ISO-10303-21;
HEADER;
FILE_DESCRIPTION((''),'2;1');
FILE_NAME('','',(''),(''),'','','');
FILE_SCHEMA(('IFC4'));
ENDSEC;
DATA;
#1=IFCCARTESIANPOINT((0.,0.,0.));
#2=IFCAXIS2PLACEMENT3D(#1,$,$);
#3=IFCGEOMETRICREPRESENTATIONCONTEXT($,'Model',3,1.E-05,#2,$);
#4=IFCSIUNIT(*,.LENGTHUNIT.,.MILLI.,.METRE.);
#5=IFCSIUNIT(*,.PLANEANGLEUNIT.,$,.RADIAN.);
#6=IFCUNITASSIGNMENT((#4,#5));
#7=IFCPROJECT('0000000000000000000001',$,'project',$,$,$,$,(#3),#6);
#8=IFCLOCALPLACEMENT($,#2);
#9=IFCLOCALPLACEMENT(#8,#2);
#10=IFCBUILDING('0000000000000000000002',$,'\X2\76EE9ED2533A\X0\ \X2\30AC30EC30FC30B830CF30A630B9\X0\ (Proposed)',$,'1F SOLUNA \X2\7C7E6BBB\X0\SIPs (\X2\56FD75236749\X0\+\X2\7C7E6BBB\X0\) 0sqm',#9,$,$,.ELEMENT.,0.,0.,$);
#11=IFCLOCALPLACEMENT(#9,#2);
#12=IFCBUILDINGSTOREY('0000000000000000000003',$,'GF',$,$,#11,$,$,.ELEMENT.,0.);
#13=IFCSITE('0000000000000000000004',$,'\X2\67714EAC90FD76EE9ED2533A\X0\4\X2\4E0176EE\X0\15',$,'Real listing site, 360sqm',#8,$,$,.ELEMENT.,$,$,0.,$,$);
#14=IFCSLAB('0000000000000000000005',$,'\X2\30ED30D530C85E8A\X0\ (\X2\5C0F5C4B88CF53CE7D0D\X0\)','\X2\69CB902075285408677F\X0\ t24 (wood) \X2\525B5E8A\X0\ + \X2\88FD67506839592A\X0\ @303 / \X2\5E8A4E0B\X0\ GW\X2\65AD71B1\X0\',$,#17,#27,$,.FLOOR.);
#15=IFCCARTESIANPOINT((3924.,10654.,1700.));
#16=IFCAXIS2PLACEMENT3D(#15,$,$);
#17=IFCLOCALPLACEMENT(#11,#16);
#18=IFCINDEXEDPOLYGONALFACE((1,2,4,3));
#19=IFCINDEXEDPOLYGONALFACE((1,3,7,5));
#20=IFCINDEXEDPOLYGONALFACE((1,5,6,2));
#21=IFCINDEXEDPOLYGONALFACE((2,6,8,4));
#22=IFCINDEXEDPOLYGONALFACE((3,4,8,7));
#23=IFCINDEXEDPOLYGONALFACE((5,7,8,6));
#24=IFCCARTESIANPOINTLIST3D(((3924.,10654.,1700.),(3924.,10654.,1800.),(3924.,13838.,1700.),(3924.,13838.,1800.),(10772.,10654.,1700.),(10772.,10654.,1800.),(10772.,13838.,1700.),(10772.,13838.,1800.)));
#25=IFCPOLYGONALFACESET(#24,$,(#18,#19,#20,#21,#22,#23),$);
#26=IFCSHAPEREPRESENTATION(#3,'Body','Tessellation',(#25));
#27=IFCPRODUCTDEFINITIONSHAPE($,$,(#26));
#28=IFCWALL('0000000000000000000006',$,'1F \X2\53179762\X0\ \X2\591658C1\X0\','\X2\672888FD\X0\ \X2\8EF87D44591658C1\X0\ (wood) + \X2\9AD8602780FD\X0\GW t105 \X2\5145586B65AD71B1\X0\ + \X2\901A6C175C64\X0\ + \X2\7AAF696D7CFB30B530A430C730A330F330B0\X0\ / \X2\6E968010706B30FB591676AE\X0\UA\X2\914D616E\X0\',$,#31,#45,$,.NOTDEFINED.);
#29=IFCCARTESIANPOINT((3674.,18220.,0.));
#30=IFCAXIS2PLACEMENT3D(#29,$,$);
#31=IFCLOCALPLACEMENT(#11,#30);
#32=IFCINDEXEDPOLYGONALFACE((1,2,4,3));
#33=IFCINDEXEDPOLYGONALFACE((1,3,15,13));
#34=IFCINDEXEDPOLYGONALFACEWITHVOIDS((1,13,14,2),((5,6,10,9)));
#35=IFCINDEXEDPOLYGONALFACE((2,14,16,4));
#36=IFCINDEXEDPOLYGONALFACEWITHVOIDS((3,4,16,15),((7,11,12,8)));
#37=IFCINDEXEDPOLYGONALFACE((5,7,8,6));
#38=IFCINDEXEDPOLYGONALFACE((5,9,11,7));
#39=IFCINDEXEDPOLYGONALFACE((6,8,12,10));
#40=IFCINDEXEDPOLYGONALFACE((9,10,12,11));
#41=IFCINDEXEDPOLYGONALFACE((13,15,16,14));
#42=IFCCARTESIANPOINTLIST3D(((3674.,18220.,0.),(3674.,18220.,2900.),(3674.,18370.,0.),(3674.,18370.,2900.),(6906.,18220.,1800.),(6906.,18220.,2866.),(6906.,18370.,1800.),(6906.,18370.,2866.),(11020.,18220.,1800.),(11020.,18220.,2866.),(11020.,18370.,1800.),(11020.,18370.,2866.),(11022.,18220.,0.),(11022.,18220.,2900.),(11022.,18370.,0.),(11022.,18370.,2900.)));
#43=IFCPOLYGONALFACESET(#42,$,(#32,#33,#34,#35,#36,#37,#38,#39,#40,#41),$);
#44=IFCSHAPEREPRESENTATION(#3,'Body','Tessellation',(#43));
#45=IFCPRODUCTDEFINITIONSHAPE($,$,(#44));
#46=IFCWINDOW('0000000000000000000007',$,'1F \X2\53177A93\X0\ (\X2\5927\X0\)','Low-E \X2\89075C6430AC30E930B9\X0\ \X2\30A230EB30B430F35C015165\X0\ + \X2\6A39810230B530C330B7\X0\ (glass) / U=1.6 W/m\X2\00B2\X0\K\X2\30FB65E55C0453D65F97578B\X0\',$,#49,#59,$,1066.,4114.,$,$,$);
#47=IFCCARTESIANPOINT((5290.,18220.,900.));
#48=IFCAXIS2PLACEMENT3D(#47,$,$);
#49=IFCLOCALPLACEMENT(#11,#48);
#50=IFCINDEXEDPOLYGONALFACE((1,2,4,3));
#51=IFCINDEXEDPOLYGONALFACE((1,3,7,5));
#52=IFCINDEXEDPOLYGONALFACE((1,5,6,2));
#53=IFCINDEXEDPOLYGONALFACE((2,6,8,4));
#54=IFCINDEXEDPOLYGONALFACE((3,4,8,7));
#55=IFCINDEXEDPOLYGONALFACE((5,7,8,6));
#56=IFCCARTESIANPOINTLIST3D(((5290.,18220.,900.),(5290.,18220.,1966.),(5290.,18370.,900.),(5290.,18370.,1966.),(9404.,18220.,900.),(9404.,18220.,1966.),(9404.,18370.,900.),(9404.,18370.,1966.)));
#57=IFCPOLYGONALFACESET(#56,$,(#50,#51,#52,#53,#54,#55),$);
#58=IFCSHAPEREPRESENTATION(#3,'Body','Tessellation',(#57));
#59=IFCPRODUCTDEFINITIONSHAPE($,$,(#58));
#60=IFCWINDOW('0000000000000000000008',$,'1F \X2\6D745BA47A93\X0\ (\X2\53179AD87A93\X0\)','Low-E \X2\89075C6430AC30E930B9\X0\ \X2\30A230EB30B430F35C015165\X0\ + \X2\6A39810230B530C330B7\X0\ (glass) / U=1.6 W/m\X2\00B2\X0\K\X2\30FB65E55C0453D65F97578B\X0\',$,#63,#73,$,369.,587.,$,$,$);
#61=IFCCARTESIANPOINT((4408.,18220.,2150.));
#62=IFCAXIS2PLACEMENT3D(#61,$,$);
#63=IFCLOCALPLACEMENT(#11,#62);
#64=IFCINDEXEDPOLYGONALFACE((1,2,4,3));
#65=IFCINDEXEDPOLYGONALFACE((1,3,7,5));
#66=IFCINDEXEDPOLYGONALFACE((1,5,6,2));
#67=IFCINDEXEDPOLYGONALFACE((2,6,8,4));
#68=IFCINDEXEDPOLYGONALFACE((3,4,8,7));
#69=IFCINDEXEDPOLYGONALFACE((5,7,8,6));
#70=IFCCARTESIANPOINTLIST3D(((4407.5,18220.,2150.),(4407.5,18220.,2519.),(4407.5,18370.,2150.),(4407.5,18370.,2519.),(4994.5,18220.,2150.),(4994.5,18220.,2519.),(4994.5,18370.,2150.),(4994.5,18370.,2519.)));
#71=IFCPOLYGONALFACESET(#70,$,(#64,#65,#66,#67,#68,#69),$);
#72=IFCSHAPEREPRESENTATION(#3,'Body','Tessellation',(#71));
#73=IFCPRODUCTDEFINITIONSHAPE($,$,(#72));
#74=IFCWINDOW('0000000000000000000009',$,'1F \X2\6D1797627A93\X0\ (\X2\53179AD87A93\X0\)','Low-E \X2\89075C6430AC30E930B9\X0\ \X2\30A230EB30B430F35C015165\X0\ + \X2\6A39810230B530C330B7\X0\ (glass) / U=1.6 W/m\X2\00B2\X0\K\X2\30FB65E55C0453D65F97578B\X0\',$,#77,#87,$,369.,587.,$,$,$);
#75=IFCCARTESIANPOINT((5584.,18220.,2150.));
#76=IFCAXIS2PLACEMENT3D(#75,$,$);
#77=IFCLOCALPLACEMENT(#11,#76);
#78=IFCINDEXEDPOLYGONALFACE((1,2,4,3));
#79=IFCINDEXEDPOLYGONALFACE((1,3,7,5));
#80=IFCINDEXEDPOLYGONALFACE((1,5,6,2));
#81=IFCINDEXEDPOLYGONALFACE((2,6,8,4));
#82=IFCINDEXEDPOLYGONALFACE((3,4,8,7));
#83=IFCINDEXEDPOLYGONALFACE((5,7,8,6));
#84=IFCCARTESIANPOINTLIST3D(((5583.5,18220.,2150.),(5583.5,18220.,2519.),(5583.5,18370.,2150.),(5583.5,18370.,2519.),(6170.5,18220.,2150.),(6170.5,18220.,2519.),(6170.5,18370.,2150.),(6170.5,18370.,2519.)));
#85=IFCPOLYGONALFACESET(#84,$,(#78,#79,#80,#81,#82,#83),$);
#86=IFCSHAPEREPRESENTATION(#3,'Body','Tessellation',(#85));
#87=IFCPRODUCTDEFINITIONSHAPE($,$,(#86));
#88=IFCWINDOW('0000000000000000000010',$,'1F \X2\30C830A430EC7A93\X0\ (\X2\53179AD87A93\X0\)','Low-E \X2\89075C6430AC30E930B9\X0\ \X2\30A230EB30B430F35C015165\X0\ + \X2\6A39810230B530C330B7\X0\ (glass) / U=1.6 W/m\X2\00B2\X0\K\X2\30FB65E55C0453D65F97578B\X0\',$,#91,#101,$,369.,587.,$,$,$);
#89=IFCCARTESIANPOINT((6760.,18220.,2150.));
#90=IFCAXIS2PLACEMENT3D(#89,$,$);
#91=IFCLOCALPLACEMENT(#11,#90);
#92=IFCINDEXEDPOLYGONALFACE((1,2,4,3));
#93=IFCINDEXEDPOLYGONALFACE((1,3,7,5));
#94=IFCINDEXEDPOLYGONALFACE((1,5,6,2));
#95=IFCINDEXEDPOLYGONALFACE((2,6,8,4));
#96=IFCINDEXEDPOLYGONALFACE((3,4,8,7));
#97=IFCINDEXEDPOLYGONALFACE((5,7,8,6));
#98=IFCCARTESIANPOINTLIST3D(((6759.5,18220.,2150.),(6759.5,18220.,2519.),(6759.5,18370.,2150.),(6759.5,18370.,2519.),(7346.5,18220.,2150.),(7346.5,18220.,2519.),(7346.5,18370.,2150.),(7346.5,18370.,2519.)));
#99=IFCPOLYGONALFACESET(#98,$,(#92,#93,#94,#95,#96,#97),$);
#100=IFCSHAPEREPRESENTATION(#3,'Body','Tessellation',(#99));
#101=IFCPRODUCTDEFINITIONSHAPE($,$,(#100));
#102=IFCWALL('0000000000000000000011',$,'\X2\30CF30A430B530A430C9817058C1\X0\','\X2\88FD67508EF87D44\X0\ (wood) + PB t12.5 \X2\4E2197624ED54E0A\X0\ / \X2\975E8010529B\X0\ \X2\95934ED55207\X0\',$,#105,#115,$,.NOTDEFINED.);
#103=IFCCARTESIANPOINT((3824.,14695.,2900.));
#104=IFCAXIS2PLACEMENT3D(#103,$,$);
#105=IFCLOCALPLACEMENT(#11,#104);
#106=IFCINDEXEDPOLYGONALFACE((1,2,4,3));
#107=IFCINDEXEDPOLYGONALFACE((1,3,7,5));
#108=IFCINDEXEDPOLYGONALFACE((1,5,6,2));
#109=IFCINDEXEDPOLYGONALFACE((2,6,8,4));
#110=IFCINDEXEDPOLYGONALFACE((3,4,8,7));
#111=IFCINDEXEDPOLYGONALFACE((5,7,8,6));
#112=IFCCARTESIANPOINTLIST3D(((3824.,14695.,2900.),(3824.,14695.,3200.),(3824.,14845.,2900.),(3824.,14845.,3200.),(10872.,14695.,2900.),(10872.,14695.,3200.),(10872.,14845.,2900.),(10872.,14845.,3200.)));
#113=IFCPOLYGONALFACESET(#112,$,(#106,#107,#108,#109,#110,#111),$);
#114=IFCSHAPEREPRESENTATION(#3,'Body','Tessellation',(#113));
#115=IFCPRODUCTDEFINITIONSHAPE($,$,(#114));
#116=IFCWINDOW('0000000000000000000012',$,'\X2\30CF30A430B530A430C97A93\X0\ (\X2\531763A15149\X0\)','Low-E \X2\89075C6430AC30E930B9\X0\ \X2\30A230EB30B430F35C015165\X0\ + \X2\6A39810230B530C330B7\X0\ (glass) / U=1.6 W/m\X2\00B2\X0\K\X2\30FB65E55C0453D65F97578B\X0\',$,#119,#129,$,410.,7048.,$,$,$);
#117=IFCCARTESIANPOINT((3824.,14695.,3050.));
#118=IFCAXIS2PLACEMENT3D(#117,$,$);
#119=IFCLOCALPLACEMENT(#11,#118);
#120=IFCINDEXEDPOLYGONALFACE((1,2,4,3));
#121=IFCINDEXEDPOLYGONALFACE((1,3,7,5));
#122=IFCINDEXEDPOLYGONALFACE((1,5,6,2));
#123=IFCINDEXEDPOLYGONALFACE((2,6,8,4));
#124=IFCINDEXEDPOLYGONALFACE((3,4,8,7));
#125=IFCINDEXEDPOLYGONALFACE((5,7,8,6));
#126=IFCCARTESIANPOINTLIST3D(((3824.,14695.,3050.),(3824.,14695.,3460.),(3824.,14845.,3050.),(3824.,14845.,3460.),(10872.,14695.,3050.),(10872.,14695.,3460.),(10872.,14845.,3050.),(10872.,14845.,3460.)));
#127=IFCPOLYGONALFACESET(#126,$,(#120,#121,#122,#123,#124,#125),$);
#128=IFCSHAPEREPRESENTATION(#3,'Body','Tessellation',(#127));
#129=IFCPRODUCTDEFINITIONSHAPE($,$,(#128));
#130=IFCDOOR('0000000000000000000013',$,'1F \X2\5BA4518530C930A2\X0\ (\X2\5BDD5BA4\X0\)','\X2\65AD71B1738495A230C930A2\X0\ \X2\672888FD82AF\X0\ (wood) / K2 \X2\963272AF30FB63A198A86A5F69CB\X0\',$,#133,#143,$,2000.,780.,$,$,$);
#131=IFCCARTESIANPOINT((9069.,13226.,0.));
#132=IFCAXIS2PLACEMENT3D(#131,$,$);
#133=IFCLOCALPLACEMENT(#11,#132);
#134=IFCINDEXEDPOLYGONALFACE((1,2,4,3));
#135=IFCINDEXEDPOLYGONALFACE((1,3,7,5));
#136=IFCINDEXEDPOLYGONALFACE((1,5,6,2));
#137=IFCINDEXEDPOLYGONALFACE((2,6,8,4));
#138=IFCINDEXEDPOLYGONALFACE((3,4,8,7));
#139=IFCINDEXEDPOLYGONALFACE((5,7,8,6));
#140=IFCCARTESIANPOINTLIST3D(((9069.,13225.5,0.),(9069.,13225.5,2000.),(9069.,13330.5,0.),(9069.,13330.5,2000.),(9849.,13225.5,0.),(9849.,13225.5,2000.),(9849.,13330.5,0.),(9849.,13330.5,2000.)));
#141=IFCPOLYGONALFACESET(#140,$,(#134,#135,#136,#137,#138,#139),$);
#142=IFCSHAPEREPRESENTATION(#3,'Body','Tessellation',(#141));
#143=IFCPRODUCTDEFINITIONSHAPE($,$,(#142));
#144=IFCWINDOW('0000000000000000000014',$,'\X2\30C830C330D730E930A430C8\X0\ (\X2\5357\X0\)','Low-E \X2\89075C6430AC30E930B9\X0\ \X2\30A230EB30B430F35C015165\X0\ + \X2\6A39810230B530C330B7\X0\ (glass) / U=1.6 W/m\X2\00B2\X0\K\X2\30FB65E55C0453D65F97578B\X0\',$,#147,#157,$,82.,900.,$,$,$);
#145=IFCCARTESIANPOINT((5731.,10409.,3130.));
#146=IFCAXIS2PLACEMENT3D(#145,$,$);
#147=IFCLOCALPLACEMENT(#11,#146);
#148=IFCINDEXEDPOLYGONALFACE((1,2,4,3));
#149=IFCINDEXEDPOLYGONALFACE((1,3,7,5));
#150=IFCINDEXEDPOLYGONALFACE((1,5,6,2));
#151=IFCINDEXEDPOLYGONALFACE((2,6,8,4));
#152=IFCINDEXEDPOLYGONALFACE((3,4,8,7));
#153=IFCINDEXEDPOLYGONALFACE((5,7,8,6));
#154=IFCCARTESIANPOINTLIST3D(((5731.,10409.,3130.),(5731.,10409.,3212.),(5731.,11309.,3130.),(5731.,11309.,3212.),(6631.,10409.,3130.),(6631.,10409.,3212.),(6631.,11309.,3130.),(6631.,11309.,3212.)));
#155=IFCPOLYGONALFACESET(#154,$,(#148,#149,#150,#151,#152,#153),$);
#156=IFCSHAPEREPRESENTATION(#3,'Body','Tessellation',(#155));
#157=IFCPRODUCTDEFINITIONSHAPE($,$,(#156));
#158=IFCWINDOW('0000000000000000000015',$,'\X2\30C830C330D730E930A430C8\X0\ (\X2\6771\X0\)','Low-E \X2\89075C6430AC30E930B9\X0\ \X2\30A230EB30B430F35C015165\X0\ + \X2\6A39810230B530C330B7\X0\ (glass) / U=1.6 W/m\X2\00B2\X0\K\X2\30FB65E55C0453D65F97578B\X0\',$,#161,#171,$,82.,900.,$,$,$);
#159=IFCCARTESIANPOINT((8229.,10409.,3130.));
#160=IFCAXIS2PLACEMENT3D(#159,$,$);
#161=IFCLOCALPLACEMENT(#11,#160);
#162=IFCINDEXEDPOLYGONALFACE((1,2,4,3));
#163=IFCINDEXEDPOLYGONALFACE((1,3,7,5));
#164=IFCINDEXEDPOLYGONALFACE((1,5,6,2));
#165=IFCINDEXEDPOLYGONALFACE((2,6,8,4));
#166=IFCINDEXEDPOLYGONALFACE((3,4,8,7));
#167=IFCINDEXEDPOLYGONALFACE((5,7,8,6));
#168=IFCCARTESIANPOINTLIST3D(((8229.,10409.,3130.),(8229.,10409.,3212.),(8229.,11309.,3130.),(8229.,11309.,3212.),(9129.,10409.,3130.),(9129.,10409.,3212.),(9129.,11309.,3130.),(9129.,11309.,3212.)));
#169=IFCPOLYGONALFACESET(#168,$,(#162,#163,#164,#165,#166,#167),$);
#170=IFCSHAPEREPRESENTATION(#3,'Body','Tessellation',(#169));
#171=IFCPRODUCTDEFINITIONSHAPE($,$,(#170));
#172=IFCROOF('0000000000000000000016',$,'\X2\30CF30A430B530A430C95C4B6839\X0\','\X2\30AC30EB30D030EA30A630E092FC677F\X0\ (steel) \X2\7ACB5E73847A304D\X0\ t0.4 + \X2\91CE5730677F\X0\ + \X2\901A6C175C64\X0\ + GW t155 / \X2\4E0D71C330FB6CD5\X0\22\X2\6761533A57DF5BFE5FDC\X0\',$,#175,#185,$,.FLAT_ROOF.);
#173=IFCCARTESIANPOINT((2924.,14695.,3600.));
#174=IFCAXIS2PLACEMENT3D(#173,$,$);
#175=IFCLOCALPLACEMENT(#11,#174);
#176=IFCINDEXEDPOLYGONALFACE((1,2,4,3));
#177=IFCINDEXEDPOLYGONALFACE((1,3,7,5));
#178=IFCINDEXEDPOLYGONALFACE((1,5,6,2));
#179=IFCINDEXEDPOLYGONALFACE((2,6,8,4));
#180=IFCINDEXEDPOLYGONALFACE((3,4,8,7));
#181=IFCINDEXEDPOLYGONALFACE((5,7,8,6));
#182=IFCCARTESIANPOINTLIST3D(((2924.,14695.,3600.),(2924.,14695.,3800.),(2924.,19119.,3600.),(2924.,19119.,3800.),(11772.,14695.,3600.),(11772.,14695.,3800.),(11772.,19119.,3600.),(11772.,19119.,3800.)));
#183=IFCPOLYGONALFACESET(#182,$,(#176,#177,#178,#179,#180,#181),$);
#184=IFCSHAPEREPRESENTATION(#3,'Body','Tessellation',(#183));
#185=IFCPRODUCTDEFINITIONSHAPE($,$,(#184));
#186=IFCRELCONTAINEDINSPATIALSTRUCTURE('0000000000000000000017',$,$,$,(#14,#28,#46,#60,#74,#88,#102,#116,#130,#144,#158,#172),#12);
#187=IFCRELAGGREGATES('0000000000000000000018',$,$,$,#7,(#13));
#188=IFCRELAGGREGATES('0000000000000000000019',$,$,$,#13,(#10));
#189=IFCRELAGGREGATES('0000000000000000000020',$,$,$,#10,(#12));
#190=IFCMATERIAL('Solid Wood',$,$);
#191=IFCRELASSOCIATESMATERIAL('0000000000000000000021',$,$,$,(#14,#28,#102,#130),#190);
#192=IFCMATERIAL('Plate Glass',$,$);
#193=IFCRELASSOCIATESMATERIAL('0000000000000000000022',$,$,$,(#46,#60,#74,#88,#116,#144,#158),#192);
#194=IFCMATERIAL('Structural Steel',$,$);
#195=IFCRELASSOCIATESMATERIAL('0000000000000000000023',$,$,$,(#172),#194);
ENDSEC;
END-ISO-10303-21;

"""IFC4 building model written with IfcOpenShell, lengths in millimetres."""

from ifc_helpers import new_model, si_unit, frame, frame_2d, origin, place, context, project, spatial, rectangle, extrude, material, element, fill, save


model = new_model("IFC4")

# Units and contexts
model_context = context("Model", 3, precision=1e-05, world=origin())
ifc_project = project(units=[si_unit("LENGTHUNIT", "METRE", prefix="MILLI"), si_unit("PLANEANGLEUNIT", "RADIAN")], contexts=[model_context])

# Site, building, storey
site_placement = place(None, origin())
site = spatial("IfcSite", under=ifc_project, at=site_placement, Name="東京都目黒区4丁目15", ObjectType="Real listing site, 360sqm", CompositionType="ELEMENT", RefElevation=0.0)
building_placement = place(site_placement, origin())
building = spatial("IfcBuilding", under=site, at=building_placement, Name="目黒区 ガレージハウス (Proposed)", ObjectType="1F SOLUNA 籾殻SIPs (国産杉+籾殻) 0sqm", CompositionType="ELEMENT", ElevationOfRefHeight=0.0, ElevationOfTerrain=0.0)
storey_placement = place(building_placement, origin())
storey = spatial("IfcBuildingStorey", under=building, at=storey_placement, Name="GF", CompositionType="ELEMENT", Elevation=0.0)

# Slab
ifc_material_1 = material(Name="Solid Wood")
slab_placement = place(storey_placement, frame((3924.0, 10654.0, 1700.0)))
element("IfcSlab", 1, at=slab_placement, inside=storey, material=ifc_material_1, Name="ロフト床 (小屋裏収納)", Description="構造用合板 t24 (wood) 剛床 + 製材根太 @303 / 床下 GW断熱", PredefinedType="FLOOR", context=model_context, shape_type="SweptSolid", body=[
    extrude(rectangle(XDim=6848.0, YDim=3184.0, at=frame_2d((3424.0, 1592.0))), frame((3924.0, 10654.0, 1700.0)), (0.0, 0.0, 1.0), 100.0),
])

# Wall, openings, windows
wall_1_placement = place(storey_placement, frame((3674.0, 18220.0, 0.0)))
wall_1 = element("IfcWall", 2, at=wall_1_placement, inside=storey, material=ifc_material_1, Name="1F 北面 外壁", Description="木製 軸組外壁 (wood) + 高性能GW t105 充填断熱 + 通気層 + 窯業系サイディング / 準耐火・外皮UA配慮", PredefinedType="NOTDEFINED", context=model_context, shape_type="SweptSolid", body=[
    extrude(rectangle(XDim=7348.0, YDim=150.0, at=frame_2d((3674.0, 75.0))), frame((3674.0, 18220.0, 0.0)), (0.0, 0.0, 1.0), 2900.0),
])
opening_1_placement = place(storey_placement, frame((5290.0, 18220.0, 900.0)))
opening_1 = element("IfcOpeningElement", 3, at=opening_1_placement, cuts=wall_1, PredefinedType="NOTDEFINED", context=model_context, shape_type="SweptSolid", body=[
    extrude(rectangle(XDim=4114.0, YDim=150.0, at=frame_2d((2057.0, 75.0))), frame((5290.0, 18220.0, 900.0)), (0.0, 0.0, 1.0), 1066.0),
])
opening_2_placement = place(storey_placement, frame((4408.0, 18220.0, 2150.0)))
opening_2 = element("IfcOpeningElement", 4, at=opening_2_placement, cuts=wall_1, PredefinedType="NOTDEFINED", context=model_context, shape_type="SweptSolid", body=[
    extrude(rectangle(XDim=587.0, YDim=150.0, at=frame_2d((293.0, 75.0))), frame((4408.0, 18220.0, 2150.0)), (0.0, 0.0, 1.0), 369.0),
])
opening_3_placement = place(storey_placement, frame((5584.0, 18220.0, 2150.0)))
opening_3 = element("IfcOpeningElement", 5, at=opening_3_placement, cuts=wall_1, PredefinedType="NOTDEFINED", context=model_context, shape_type="SweptSolid", body=[
    extrude(rectangle(XDim=587.0, YDim=150.0, at=frame_2d((293.0, 75.0))), frame((5584.0, 18220.0, 2150.0)), (0.0, 0.0, 1.0), 369.0),
])
opening_4_placement = place(storey_placement, frame((6760.0, 18220.0, 2150.0)))
opening_4 = element("IfcOpeningElement", 6, at=opening_4_placement, cuts=wall_1, PredefinedType="NOTDEFINED", context=model_context, shape_type="SweptSolid", body=[
    extrude(rectangle(XDim=587.0, YDim=150.0, at=frame_2d((293.0, 75.0))), frame((6760.0, 18220.0, 2150.0)), (0.0, 0.0, 1.0), 369.0),
])
ifc_material_2 = material(Name="Plate Glass")
window_1_placement = place(storey_placement, frame((5290.0, 18220.0, 900.0)))
window_1 = element("IfcWindow", 7, at=window_1_placement, inside=storey, material=ifc_material_2, Name="1F 北窓 (大)", Description="Low-E 複層ガラス アルゴン封入 + 樹脂サッシ (glass) / U=1.6 W/m²K・日射取得型", OverallHeight=1066.0, OverallWidth=4114.0, context=model_context, shape_type="SweptSolid", body=[
    extrude(rectangle(XDim=4114.0, YDim=150.0, at=frame_2d((2057.0, 75.0))), frame((5290.0, 18220.0, 900.0)), (0.0, 0.0, 1.0), 1066.0),
])
fill(opening_1, window_1)
window_2_placement = place(storey_placement, frame((4408.0, 18220.0, 2150.0)))
window_2 = element("IfcWindow", 8, at=window_2_placement, inside=storey, material=ifc_material_2, Name="1F 浴室窓 (北高窓)", Description="Low-E 複層ガラス アルゴン封入 + 樹脂サッシ (glass) / U=1.6 W/m²K・日射取得型", OverallHeight=369.0, OverallWidth=587.0, context=model_context, shape_type="SweptSolid", body=[
    extrude(rectangle(XDim=587.0, YDim=150.0, at=frame_2d((293.0, 75.0))), frame((4408.0, 18220.0, 2150.0)), (0.0, 0.0, 1.0), 369.0),
])
fill(opening_2, window_2)
window_3_placement = place(storey_placement, frame((5584.0, 18220.0, 2150.0)))
window_3 = element("IfcWindow", 9, at=window_3_placement, inside=storey, material=ifc_material_2, Name="1F 洗面窓 (北高窓)", Description="Low-E 複層ガラス アルゴン封入 + 樹脂サッシ (glass) / U=1.6 W/m²K・日射取得型", OverallHeight=369.0, OverallWidth=587.0, context=model_context, shape_type="SweptSolid", body=[
    extrude(rectangle(XDim=587.0, YDim=150.0, at=frame_2d((293.0, 75.0))), frame((5584.0, 18220.0, 2150.0)), (0.0, 0.0, 1.0), 369.0),
])
fill(opening_3, window_3)
window_4_placement = place(storey_placement, frame((6760.0, 18220.0, 2150.0)))
window_4 = element("IfcWindow", 10, at=window_4_placement, inside=storey, material=ifc_material_2, Name="1F トイレ窓 (北高窓)", Description="Low-E 複層ガラス アルゴン封入 + 樹脂サッシ (glass) / U=1.6 W/m²K・日射取得型", OverallHeight=369.0, OverallWidth=587.0, context=model_context, shape_type="SweptSolid", body=[
    extrude(rectangle(XDim=587.0, YDim=150.0, at=frame_2d((293.0, 75.0))), frame((6760.0, 18220.0, 2150.0)), (0.0, 0.0, 1.0), 369.0),
])
fill(opening_4, window_4)

# Wall, opening, window
wall_2_placement = place(storey_placement, frame((3824.0, 14695.0, 2900.0)))
wall_2 = element("IfcWall", 11, at=wall_2_placement, inside=storey, material=ifc_material_1, Name="ハイサイド腰壁", Description="製材軸組 (wood) + PB t12.5 両面仕上 / 非耐力 間仕切", PredefinedType="NOTDEFINED", context=model_context, shape_type="SweptSolid", body=[
    extrude(rectangle(XDim=7048.0, YDim=150.0, at=frame_2d((3524.0, 75.0))), frame((3824.0, 14695.0, 2900.0)), (0.0, 0.0, 1.0), 700.0),
])
opening_5_placement = place(storey_placement, frame((3824.0, 14695.0, 3050.0)))
opening_5 = element("IfcOpeningElement", 12, at=opening_5_placement, cuts=wall_2, PredefinedType="NOTDEFINED", context=model_context, shape_type="SweptSolid", body=[
    extrude(rectangle(XDim=7048.0, YDim=150.0, at=frame_2d((3524.0, 75.0))), frame((3824.0, 14695.0, 3050.0)), (0.0, 0.0, 1.0), 410.0),
])
window_5_placement = place(storey_placement, frame((3824.0, 14695.0, 3050.0)))
window_5 = element("IfcWindow", 13, at=window_5_placement, inside=storey, material=ifc_material_2, Name="ハイサイド窓 (北採光)", Description="Low-E 複層ガラス アルゴン封入 + 樹脂サッシ (glass) / U=1.6 W/m²K・日射取得型", OverallHeight=410.0, OverallWidth=7048.0, context=model_context, shape_type="SweptSolid", body=[
    extrude(rectangle(XDim=7048.0, YDim=150.0, at=frame_2d((3524.0, 75.0))), frame((3824.0, 14695.0, 3050.0)), (0.0, 0.0, 1.0), 410.0),
])
fill(opening_5, window_5)

# Door
door_1_placement = place(storey_placement, frame((9069.0, 13226.0, 0.0)))
element("IfcDoor", 14, at=door_1_placement, inside=storey, material=ifc_material_1, Name="1F 室内ドア (寝室)", Description="断熱玄関ドア 木製芯 (wood) / K2 防犯・採風機構", OverallHeight=2000.0, OverallWidth=780.0, context=model_context, shape_type="SweptSolid", body=[
    extrude(rectangle(XDim=780.0, YDim=105.0, at=frame_2d((390.0, 52.0))), frame((9069.0, 13226.0, 0.0)), (0.0, 0.0, 1.0), 2000.0),
])

# Windows
window_6_placement = place(storey_placement, frame((5731.0, 10409.0, 3130.0)))
element("IfcWindow", 15, at=window_6_placement, inside=storey, material=ifc_material_2, Name="トップライト (南)", Description="Low-E 複層ガラス アルゴン封入 + 樹脂サッシ (glass) / U=1.6 W/m²K・日射取得型", OverallHeight=82.0, OverallWidth=900.0, context=model_context, shape_type="SweptSolid", body=[
    extrude(rectangle(XDim=900.0, YDim=900.0, at=frame_2d((450.0, 450.0))), frame((5731.0, 10409.0, 3130.0)), (0.0, 0.0, 1.0), 82.0),
])
window_7_placement = place(storey_placement, frame((8229.0, 10409.0, 3130.0)))
element("IfcWindow", 16, at=window_7_placement, inside=storey, material=ifc_material_2, Name="トップライト (東)", Description="Low-E 複層ガラス アルゴン封入 + 樹脂サッシ (glass) / U=1.6 W/m²K・日射取得型", OverallHeight=82.0, OverallWidth=900.0, context=model_context, shape_type="SweptSolid", body=[
    extrude(rectangle(XDim=900.0, YDim=900.0, at=frame_2d((450.0, 450.0))), frame((8229.0, 10409.0, 3130.0)), (0.0, 0.0, 1.0), 82.0),
])

# Roof
ifc_material_3 = material(Name="Structural Steel")
roof_placement = place(storey_placement, frame((2924.0, 14695.0, 3600.0)))
element("IfcRoof", 17, at=roof_placement, inside=storey, material=ifc_material_3, Name="ハイサイド屋根", Description="ガルバリウム鋼板 (steel) 立平葺き t0.4 + 野地板 + 通気層 + GW t155 / 不燃・法22条区域対応", PredefinedType="FLAT_ROOF", context=model_context, shape_type="SweptSolid", body=[
    extrude(rectangle(XDim=8848.0, YDim=4424.0, at=frame_2d((4424.0, 2212.0))), frame((2924.0, 14695.0, 3600.0)), (0.0, 0.0, 1.0), 200.0),
])

save(model, "model.ifc")
